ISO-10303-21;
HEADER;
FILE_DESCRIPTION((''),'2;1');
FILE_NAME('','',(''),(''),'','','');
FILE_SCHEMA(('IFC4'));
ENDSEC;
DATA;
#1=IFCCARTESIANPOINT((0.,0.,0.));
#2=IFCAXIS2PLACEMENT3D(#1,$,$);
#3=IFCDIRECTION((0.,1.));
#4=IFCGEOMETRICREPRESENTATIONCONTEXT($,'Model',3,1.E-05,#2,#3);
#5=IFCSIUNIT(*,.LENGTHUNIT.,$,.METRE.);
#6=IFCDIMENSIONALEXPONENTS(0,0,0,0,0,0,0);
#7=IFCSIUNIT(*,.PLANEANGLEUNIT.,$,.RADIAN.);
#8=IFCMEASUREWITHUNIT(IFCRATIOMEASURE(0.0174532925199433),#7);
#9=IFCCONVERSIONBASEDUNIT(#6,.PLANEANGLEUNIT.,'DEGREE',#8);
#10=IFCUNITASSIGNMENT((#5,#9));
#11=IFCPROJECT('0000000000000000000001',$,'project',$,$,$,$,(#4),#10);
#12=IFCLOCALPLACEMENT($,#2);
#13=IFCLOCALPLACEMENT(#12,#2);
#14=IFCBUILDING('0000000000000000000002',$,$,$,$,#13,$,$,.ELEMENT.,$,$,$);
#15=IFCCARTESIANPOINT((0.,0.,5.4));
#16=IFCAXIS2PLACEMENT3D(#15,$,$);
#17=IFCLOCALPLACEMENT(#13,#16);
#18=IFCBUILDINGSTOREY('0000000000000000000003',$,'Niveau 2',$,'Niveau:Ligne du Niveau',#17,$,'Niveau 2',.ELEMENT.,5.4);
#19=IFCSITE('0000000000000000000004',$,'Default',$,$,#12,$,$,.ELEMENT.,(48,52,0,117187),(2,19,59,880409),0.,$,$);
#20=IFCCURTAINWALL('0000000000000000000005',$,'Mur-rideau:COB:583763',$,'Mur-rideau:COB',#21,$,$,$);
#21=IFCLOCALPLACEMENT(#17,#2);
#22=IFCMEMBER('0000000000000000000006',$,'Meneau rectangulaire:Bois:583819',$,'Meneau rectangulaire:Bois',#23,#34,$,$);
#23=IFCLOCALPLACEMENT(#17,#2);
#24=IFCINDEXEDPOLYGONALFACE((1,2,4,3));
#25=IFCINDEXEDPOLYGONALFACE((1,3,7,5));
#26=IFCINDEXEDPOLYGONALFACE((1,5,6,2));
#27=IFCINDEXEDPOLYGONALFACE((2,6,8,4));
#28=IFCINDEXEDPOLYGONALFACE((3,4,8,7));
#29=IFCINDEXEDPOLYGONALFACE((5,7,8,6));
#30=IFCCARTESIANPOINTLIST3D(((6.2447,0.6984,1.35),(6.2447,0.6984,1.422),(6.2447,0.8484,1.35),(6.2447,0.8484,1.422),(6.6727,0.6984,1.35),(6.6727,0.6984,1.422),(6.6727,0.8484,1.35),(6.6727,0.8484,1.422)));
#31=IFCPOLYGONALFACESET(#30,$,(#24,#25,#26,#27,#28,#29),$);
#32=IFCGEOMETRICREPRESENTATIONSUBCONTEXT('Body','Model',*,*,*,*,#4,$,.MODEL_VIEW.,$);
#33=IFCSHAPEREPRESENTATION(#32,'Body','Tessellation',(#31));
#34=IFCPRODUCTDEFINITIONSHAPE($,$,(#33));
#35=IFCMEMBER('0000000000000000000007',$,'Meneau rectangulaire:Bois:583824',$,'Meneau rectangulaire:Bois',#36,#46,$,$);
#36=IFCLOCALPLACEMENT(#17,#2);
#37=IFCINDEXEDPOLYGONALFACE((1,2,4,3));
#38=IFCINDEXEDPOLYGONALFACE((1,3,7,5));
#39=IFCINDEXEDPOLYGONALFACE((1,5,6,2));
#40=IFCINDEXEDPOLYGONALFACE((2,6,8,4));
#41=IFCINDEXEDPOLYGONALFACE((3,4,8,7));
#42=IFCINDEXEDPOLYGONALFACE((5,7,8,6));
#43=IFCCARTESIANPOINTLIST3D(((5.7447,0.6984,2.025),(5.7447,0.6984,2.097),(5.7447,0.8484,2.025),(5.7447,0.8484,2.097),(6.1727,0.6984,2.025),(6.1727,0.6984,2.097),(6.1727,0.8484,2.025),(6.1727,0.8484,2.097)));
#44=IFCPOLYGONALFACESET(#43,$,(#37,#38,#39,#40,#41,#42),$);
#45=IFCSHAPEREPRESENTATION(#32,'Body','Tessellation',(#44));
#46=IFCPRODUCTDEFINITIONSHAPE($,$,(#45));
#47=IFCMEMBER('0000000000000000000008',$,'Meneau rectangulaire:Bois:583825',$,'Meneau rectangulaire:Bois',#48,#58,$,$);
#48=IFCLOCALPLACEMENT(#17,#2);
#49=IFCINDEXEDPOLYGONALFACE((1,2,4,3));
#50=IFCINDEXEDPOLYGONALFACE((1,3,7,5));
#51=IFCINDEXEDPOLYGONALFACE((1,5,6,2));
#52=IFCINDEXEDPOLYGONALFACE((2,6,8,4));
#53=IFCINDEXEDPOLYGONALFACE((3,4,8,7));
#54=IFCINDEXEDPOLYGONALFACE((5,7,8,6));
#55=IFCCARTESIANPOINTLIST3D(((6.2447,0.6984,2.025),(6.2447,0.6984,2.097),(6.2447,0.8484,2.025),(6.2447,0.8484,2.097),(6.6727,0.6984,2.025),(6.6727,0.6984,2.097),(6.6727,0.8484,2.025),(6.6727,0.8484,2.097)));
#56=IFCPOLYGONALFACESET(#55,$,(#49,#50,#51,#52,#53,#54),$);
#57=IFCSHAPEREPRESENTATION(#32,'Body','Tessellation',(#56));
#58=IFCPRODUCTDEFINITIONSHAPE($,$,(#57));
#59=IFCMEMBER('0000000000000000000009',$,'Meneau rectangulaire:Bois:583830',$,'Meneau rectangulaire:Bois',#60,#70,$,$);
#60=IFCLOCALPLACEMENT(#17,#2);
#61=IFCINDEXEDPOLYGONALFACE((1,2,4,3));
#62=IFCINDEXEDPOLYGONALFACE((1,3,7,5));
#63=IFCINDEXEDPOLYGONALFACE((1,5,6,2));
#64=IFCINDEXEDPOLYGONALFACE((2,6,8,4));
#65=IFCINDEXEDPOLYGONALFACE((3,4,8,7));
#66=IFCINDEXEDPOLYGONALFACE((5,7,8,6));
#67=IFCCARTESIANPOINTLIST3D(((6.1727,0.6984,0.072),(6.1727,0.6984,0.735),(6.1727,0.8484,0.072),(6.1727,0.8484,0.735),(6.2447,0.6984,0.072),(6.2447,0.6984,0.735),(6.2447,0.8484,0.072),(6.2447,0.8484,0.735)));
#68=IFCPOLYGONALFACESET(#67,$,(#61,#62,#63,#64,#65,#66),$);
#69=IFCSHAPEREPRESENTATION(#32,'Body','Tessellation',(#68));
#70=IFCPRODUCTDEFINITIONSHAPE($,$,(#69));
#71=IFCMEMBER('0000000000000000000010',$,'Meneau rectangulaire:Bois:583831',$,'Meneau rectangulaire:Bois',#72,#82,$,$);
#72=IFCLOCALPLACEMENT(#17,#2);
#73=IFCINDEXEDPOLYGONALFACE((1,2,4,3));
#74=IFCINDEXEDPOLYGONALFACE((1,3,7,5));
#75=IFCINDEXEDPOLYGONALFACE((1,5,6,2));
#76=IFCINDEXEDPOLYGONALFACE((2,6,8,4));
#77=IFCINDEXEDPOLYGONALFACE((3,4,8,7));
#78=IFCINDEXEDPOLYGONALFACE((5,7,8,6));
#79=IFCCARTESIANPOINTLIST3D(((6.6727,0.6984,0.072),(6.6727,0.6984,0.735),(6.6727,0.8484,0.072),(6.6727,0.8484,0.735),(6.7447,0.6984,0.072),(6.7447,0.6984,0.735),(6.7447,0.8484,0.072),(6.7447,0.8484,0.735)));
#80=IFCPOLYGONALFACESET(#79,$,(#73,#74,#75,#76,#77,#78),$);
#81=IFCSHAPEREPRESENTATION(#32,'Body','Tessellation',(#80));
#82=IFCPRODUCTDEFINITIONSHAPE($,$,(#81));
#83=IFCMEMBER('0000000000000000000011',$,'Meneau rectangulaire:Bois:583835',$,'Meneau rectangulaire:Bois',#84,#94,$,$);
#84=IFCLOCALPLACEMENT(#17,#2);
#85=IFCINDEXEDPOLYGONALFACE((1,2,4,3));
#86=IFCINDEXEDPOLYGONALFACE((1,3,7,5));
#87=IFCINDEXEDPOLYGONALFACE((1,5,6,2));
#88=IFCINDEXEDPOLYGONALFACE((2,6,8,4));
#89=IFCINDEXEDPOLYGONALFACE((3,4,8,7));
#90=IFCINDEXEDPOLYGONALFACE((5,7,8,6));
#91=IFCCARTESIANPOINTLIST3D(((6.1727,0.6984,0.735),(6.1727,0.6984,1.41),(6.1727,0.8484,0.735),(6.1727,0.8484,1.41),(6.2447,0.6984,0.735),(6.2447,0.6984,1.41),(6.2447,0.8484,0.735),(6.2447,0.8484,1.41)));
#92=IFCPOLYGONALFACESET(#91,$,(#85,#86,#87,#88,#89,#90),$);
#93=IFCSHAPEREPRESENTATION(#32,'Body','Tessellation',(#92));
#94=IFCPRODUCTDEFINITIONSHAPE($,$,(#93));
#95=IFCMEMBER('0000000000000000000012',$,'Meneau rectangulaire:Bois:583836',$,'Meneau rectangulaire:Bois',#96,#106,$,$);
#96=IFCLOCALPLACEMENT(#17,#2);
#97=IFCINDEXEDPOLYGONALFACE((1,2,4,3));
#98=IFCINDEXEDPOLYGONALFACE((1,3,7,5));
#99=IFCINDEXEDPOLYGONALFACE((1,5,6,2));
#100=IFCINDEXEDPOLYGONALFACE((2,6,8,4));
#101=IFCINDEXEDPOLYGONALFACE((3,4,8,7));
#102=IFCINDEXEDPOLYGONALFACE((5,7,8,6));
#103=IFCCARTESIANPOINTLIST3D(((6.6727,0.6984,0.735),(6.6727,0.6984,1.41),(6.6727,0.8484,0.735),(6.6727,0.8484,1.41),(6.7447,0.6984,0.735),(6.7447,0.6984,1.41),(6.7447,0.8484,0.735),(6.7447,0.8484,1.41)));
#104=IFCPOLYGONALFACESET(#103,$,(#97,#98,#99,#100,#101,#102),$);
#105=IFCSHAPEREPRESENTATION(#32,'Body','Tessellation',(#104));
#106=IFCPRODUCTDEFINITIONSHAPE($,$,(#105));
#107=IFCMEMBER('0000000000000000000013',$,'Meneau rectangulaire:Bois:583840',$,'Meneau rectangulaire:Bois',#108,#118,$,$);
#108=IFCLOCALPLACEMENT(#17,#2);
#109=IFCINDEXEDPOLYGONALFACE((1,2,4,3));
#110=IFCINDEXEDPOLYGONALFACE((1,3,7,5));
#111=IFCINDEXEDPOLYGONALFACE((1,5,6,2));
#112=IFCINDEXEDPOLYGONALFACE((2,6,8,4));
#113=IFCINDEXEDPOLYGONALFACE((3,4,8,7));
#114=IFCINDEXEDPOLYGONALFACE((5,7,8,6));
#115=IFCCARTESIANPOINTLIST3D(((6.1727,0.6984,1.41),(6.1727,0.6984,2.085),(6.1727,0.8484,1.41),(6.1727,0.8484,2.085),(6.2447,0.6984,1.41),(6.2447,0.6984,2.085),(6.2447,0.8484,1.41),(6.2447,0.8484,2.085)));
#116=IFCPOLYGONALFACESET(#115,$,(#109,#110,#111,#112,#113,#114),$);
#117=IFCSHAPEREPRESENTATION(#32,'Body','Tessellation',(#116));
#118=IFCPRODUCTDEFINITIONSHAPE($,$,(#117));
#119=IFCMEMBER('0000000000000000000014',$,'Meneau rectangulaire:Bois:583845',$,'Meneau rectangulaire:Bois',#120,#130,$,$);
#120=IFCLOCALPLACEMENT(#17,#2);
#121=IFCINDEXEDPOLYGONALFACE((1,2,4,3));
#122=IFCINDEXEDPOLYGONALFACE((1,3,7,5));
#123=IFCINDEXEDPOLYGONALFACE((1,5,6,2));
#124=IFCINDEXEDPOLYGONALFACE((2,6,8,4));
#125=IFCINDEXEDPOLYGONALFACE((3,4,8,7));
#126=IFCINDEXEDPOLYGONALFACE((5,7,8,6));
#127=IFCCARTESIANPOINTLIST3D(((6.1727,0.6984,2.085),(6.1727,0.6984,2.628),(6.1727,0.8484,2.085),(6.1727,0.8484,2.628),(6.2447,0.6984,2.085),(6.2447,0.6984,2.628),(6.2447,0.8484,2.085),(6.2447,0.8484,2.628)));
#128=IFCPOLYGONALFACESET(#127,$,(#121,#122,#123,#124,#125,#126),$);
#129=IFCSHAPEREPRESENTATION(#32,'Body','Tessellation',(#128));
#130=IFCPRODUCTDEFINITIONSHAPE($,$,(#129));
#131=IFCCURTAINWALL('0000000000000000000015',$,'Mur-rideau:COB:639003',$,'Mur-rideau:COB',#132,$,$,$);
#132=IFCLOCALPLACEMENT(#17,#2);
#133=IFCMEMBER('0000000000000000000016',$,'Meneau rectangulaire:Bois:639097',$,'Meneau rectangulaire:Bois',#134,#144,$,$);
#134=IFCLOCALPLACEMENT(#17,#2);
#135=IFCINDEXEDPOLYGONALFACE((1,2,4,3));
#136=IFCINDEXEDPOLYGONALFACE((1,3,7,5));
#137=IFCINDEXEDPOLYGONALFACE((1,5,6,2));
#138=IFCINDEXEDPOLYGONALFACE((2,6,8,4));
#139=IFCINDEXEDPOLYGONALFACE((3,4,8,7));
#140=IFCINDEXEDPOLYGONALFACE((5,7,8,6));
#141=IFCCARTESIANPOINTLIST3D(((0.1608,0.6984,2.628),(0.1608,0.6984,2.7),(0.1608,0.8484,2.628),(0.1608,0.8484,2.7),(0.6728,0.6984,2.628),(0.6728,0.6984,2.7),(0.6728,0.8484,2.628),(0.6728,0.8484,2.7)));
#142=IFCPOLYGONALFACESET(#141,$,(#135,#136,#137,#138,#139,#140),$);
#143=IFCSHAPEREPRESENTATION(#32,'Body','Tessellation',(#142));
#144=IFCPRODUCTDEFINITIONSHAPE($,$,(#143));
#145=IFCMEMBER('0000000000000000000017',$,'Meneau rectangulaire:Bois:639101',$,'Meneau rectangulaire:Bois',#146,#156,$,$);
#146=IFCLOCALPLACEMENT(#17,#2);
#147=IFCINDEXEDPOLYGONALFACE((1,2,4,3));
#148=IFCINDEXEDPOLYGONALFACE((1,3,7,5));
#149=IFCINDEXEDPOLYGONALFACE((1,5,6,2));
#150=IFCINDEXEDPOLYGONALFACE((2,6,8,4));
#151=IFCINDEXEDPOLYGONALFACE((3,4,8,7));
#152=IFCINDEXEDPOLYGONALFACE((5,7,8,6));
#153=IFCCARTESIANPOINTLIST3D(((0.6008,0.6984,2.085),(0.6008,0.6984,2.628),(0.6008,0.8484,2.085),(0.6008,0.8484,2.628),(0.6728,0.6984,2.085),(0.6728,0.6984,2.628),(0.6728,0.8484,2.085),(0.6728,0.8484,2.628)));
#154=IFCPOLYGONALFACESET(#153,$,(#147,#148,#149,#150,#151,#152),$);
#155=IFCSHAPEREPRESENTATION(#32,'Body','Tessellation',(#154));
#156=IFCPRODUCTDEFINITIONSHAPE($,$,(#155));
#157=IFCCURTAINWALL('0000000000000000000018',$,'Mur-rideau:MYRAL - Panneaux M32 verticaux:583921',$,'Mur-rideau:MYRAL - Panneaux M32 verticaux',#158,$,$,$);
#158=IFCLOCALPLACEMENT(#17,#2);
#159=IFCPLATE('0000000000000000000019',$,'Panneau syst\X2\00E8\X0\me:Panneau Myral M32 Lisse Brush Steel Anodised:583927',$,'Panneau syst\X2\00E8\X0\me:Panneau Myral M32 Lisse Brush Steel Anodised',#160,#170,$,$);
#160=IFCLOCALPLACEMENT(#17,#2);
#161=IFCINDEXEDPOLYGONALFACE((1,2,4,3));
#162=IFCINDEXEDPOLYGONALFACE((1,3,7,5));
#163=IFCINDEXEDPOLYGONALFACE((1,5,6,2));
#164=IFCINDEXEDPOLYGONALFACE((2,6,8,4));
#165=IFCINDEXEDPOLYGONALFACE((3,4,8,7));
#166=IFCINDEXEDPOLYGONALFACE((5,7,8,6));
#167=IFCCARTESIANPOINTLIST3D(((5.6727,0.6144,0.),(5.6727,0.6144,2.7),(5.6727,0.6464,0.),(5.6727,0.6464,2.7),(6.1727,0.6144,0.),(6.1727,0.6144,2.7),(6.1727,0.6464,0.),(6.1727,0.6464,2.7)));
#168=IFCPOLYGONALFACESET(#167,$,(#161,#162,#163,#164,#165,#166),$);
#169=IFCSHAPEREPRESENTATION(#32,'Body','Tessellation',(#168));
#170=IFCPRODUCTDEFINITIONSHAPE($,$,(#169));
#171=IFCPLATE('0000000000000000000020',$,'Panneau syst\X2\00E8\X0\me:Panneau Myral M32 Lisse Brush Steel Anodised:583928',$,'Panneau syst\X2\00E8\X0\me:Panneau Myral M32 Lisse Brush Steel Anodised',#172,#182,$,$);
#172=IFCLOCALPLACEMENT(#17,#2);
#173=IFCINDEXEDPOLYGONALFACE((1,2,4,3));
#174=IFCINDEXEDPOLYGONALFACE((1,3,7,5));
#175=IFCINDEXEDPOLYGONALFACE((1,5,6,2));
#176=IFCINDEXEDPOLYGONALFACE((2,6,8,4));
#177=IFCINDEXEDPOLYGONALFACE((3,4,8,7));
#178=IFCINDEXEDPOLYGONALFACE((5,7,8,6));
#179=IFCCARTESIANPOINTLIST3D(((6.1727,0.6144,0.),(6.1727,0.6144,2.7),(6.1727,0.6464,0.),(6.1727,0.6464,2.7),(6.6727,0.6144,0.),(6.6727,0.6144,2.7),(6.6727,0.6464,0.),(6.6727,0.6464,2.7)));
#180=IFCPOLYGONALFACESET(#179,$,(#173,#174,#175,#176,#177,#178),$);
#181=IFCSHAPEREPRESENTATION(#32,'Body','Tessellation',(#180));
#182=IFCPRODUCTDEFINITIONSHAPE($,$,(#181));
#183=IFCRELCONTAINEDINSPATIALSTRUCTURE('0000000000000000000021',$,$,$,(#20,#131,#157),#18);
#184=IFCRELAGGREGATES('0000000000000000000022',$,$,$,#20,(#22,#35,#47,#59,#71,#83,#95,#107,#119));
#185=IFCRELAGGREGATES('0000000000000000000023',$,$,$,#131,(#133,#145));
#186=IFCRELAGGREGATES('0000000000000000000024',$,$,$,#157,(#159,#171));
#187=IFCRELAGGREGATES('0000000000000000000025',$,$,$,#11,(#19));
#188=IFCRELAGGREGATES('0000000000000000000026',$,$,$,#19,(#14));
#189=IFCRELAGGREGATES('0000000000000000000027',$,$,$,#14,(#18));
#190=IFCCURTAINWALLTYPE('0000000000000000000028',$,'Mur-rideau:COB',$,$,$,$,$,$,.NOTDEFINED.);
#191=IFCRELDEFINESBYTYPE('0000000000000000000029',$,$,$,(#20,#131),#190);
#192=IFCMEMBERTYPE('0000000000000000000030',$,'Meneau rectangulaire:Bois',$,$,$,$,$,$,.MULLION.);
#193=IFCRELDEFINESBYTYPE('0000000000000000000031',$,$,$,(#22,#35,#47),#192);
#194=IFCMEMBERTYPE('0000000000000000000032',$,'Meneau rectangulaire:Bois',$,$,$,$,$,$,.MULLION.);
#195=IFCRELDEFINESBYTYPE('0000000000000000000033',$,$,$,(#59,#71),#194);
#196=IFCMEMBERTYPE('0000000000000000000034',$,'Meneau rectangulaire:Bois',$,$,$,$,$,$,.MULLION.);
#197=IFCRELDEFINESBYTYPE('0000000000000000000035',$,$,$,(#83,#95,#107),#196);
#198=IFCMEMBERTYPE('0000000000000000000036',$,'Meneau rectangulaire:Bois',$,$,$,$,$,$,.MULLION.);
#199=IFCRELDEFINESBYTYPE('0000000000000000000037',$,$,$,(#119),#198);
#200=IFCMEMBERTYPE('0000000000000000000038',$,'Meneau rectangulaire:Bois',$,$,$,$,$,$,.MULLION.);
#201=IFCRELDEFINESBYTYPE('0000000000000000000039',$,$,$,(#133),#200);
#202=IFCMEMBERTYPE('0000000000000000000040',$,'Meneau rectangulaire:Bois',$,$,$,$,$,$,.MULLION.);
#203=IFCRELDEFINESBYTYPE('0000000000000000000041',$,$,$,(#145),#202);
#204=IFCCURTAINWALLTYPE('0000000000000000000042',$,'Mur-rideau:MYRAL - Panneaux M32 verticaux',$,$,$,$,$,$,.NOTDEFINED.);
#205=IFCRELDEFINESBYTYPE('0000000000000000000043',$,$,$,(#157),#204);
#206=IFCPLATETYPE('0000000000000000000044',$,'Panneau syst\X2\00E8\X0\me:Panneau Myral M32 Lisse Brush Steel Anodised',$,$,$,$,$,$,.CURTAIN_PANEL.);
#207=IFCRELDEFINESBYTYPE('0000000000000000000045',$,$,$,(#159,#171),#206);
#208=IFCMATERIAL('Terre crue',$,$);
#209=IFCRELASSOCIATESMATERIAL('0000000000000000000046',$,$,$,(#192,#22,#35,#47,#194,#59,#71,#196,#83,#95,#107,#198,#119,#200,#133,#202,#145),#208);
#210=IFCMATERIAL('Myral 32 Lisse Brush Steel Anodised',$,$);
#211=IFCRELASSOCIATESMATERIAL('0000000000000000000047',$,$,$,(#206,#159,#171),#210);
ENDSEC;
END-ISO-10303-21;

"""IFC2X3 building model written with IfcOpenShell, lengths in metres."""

from ifc_helpers import new_model, entity, si_unit, converted_unit, direction, frame, origin, origin_2d_with_axis, place, context, subcontext, project, spatial, rectangle, extrude, source, transform, mapped, material, type_object, type_shapes, element, aggregate, save


model = new_model("IFC2X3")

# Units and contexts
model_context = context("Model", 3, precision=1e-05, world=origin(), true_north=direction((0.0, 1.0)))
body_context = subcontext(model_context, "Body", "Model", "MODEL_VIEW")
ifc_project = project(units=[si_unit("LENGTHUNIT", "METRE"), converted_unit("PLANEANGLEUNIT", "DEGREE", entity("IfcRatioMeasure", 0.0174532925199433), si_unit("PLANEANGLEUNIT", "RADIAN"), dimensions=[0, 0, 0, 0, 0, 0, 0])], contexts=[model_context])

# Site, building, storey
site_placement = place(None, origin())
site = spatial("IfcSite", under=ifc_project, at=site_placement, Name="Default", CompositionType="ELEMENT", RefLatitude=(48, 52, 0, 117187), RefLongitude=(2, 19, 59, 880409), RefElevation=0.0)
building_placement = place(site_placement, origin())
building = spatial("IfcBuilding", under=site, at=building_placement, CompositionType="ELEMENT")
storey_placement = place(building_placement, frame((0.0, 0.0, 5.4)))
storey = spatial("IfcBuildingStorey", under=building, at=storey_placement, Name="Niveau 2", ObjectType="Niveau:Ligne du Niveau", LongName="Niveau 2", CompositionType="ELEMENT", Elevation=5.4)

# Curtain walls, members
curtain_wall_type_1 = type_object("IfcCurtainWallType", Name="Mur-rideau:COB", PredefinedType="NOTDEFINED")
curtain_wall_1_placement = place(storey_placement, frame((0.0, 0.0, -5.4)))
curtain_wall_1 = element("IfcCurtainWall", 1, at=curtain_wall_1_placement, inside=storey, type_object=curtain_wall_type_1, Name="Mur-rideau:COB:583763", ObjectType="Mur-rideau:COB")
ifc_material_1 = material(Name="Terre crue")
member_type_1 = type_object("IfcMemberType", Name="Meneau rectangulaire:Bois", PredefinedType="MULLION", material=ifc_material_1)
shared_shape_1 = source(origin(), body_context, "Body", "SweptSolid", [
    extrude(rectangle(XDim=0.15, YDim=0.072, at=origin_2d_with_axis()), frame((-0.024, 0.0, -0.428), z_axis=(0.0, 0.0, 1.0), x_axis=(0.0, -1.0, 0.0)), (0.0, 0.0, 1.0), 0.428),
])
type_shapes(member_type_1, [shared_shape_1])
member_1_placement = place(storey_placement, frame((6.6727, 0.7734, 1.41), z_axis=(1.0, 0.0, 0.0), x_axis=(0.0, 0.0, 1.0)))
member_1 = element("IfcMember", 2, at=member_1_placement, type_object=member_type_1, material=ifc_material_1, Name="Meneau rectangulaire:Bois:583819", ObjectType="Meneau rectangulaire:Bois", context=body_context, shape_type="MappedRepresentation", body=[
    mapped(shared_shape_1, transform((0.0, 0.0, 0.0), scale=1.0)),
])
member_2_placement = place(storey_placement, frame((6.1727, 0.7734, 2.085), z_axis=(1.0, 0.0, 0.0), x_axis=(0.0, 0.0, 1.0)))
member_2 = element("IfcMember", 3, at=member_2_placement, type_object=member_type_1, material=ifc_material_1, Name="Meneau rectangulaire:Bois:583824", ObjectType="Meneau rectangulaire:Bois", context=body_context, shape_type="MappedRepresentation", body=[
    mapped(shared_shape_1, transform((0.0, 0.0, 0.0), scale=1.0)),
])
member_3_placement = place(storey_placement, frame((6.6727, 0.7734, 2.085), z_axis=(1.0, 0.0, 0.0), x_axis=(0.0, 0.0, 1.0)))
member_3 = element("IfcMember", 4, at=member_3_placement, type_object=member_type_1, material=ifc_material_1, Name="Meneau rectangulaire:Bois:583825", ObjectType="Meneau rectangulaire:Bois", context=body_context, shape_type="MappedRepresentation", body=[
    mapped(shared_shape_1, transform((0.0, 0.0, 0.0), scale=1.0)),
])
member_type_2 = type_object("IfcMemberType", Name="Meneau rectangulaire:Bois", PredefinedType="MULLION", material=ifc_material_1)
shared_shape_2 = source(origin(), body_context, "Body", "SweptSolid", [
    extrude(rectangle(XDim=0.15, YDim=0.072, at=origin_2d_with_axis()), frame((-0.024, 0.0, -0.663), z_axis=(0.0, 0.0, 1.0), x_axis=(0.0, -1.0, 0.0)), (0.0, 0.0, 1.0), 0.663),
])
type_shapes(member_type_2, [shared_shape_2])
member_4_placement = place(storey_placement, frame((6.2327, 0.7734, 0.072), z_axis=(0.0, 0.0, -1.0), x_axis=(1.0, 0.0, 0.0)))
member_4 = element("IfcMember", 5, at=member_4_placement, type_object=member_type_2, material=ifc_material_1, Name="Meneau rectangulaire:Bois:583830", ObjectType="Meneau rectangulaire:Bois", context=body_context, shape_type="MappedRepresentation", body=[
    mapped(shared_shape_2, transform((0.0, 0.0, 0.0), scale=1.0)),
])
member_5_placement = place(storey_placement, frame((6.7327, 0.7734, 0.072), z_axis=(0.0, 0.0, -1.0), x_axis=(1.0, 0.0, 0.0)))
member_5 = element("IfcMember", 6, at=member_5_placement, type_object=member_type_2, material=ifc_material_1, Name="Meneau rectangulaire:Bois:583831", ObjectType="Meneau rectangulaire:Bois", context=body_context, shape_type="MappedRepresentation", body=[
    mapped(shared_shape_2, transform((0.0, 0.0, 0.0), scale=1.0)),
])
member_type_3 = type_object("IfcMemberType", Name="Meneau rectangulaire:Bois", PredefinedType="MULLION", material=ifc_material_1)
shared_shape_3 = source(origin(), body_context, "Body", "SweptSolid", [
    extrude(rectangle(XDim=0.15, YDim=0.072, at=origin_2d_with_axis()), frame((-0.024, 0.0, -0.675), z_axis=(0.0, 0.0, 1.0), x_axis=(0.0, -1.0, 0.0)), (0.0, 0.0, 1.0), 0.675),
])
type_shapes(member_type_3, [shared_shape_3])
member_6_placement = place(storey_placement, frame((6.2327, 0.7734, 0.735), z_axis=(0.0, 0.0, -1.0), x_axis=(1.0, 0.0, 0.0)))
member_6 = element("IfcMember", 7, at=member_6_placement, type_object=member_type_3, material=ifc_material_1, Name="Meneau rectangulaire:Bois:583835", ObjectType="Meneau rectangulaire:Bois", context=body_context, shape_type="MappedRepresentation", body=[
    mapped(shared_shape_3, transform((0.0, 0.0, 0.0), scale=1.0)),
])
member_7_placement = place(storey_placement, frame((6.7327, 0.7734, 0.735), z_axis=(0.0, 0.0, -1.0), x_axis=(1.0, 0.0, 0.0)))
member_7 = element("IfcMember", 8, at=member_7_placement, type_object=member_type_3, material=ifc_material_1, Name="Meneau rectangulaire:Bois:583836", ObjectType="Meneau rectangulaire:Bois", context=body_context, shape_type="MappedRepresentation", body=[
    mapped(shared_shape_3, transform((0.0, 0.0, 0.0), scale=1.0)),
])
member_8_placement = place(storey_placement, frame((6.2327, 0.7734, 1.41), z_axis=(0.0, 0.0, -1.0), x_axis=(1.0, 0.0, 0.0)))
member_8 = element("IfcMember", 9, at=member_8_placement, type_object=member_type_3, material=ifc_material_1, Name="Meneau rectangulaire:Bois:583840", ObjectType="Meneau rectangulaire:Bois", context=body_context, shape_type="MappedRepresentation", body=[
    mapped(shared_shape_3, transform((0.0, 0.0, 0.0), scale=1.0)),
])
member_type_4 = type_object("IfcMemberType", Name="Meneau rectangulaire:Bois", PredefinedType="MULLION", material=ifc_material_1)
shared_shape_4 = source(origin(), body_context, "Body", "SweptSolid", [
    extrude(rectangle(XDim=0.15, YDim=0.072, at=origin_2d_with_axis()), frame((-0.024, 0.0, -0.543), z_axis=(0.0, 0.0, 1.0), x_axis=(0.0, -1.0, 0.0)), (0.0, 0.0, 1.0), 0.543),
])
type_shapes(member_type_4, [shared_shape_4])
member_9_placement = place(storey_placement, frame((6.2327, 0.7734, 2.085), z_axis=(0.0, 0.0, -1.0), x_axis=(1.0, 0.0, 0.0)))
member_9 = element("IfcMember", 10, at=member_9_placement, type_object=member_type_4, material=ifc_material_1, Name="Meneau rectangulaire:Bois:583845", ObjectType="Meneau rectangulaire:Bois", context=body_context, shape_type="MappedRepresentation", body=[
    mapped(shared_shape_4, transform((0.0, 0.0, 0.0), scale=1.0)),
])
aggregate(curtain_wall_1, [member_1, member_2, member_3, member_4, member_5, member_6, member_7, member_8, member_9])
curtain_wall_2_placement = place(storey_placement, frame((0.0, 0.0, -5.4)))
curtain_wall_2 = element("IfcCurtainWall", 11, at=curtain_wall_2_placement, inside=storey, type_object=curtain_wall_type_1, Name="Mur-rideau:COB:639003", ObjectType="Mur-rideau:COB")
member_type_5 = type_object("IfcMemberType", Name="Meneau rectangulaire:Bois", PredefinedType="MULLION", material=ifc_material_1)
shared_shape_5 = source(origin(), body_context, "Body", "SweptSolid", [
    extrude(rectangle(XDim=0.15, YDim=0.072, at=origin_2d_with_axis()), frame((-0.036, 0.0, -0.512), z_axis=(0.0, 0.0, 1.0), x_axis=(0.0, -1.0, 0.0)), (0.0, 0.0, 1.0), 0.512),
])
type_shapes(member_type_5, [shared_shape_5])
member_10_placement = place(storey_placement, frame((0.6728, 0.7734, 2.7), z_axis=(1.0, 0.0, 0.0), x_axis=(0.0, 0.0, 1.0)))
member_10 = element("IfcMember", 12, at=member_10_placement, type_object=member_type_5, material=ifc_material_1, Name="Meneau rectangulaire:Bois:639097", ObjectType="Meneau rectangulaire:Bois", context=body_context, shape_type="MappedRepresentation", body=[
    mapped(shared_shape_5, transform((0.0, 0.0, 0.0), scale=1.0)),
])
member_type_6 = type_object("IfcMemberType", Name="Meneau rectangulaire:Bois", PredefinedType="MULLION", material=ifc_material_1)
shared_shape_6 = source(origin(), body_context, "Body", "SweptSolid", [
    extrude(rectangle(XDim=0.15, YDim=0.072, at=origin_2d_with_axis()), frame((-0.024, 0.0, -0.543), z_axis=(0.0, 0.0, 1.0), x_axis=(0.0, -1.0, 0.0)), (0.0, 0.0, 1.0), 0.543),
])
type_shapes(member_type_6, [shared_shape_6])
member_11_placement = place(storey_placement, frame((0.6608, 0.7734, 2.085), z_axis=(0.0, 0.0, -1.0), x_axis=(1.0, 0.0, 0.0)))
member_11 = element("IfcMember", 13, at=member_11_placement, type_object=member_type_6, material=ifc_material_1, Name="Meneau rectangulaire:Bois:639101", ObjectType="Meneau rectangulaire:Bois", context=body_context, shape_type="MappedRepresentation", body=[
    mapped(shared_shape_6, transform((0.0, 0.0, 0.0), scale=1.0)),
])
aggregate(curtain_wall_2, [member_10, member_11])

# Curtain wall, plates
curtain_wall_type_2 = type_object("IfcCurtainWallType", Name="Mur-rideau:MYRAL - Panneaux M32 verticaux", PredefinedType="NOTDEFINED")
curtain_wall_3_placement = place(storey_placement, frame((0.0, 0.0, -5.4)))
curtain_wall_3 = element("IfcCurtainWall", 14, at=curtain_wall_3_placement, inside=storey, type_object=curtain_wall_type_2, Name="Mur-rideau:MYRAL - Panneaux M32 verticaux:583921", ObjectType="Mur-rideau:MYRAL - Panneaux M32 verticaux")
ifc_material_2 = material(Name="Myral 32 Lisse Brush Steel Anodised")
plate_type = type_object("IfcPlateType", Name="Panneau système:Panneau Myral M32 Lisse Brush Steel Anodised", PredefinedType="CURTAIN_PANEL", material=ifc_material_2)
shared_shape_7 = source(origin(), body_context, "Body", "SweptSolid", [
    extrude(rectangle(XDim=0.032, YDim=0.5, at=origin_2d_with_axis()), frame((0.0, -0.016, 0.0), z_axis=(0.0, 0.0, 1.0), x_axis=(0.0, 1.0, 0.0)), (0.0, 0.0, 1.0), 2.7),
])
type_shapes(plate_type, [shared_shape_7])
plate_1_placement = place(curtain_wall_3_placement, frame((5.9227, 0.6464, 5.4)))
plate_1 = element("IfcPlate", 15, at=plate_1_placement, type_object=plate_type, material=ifc_material_2, Name="Panneau système:Panneau Myral M32 Lisse Brush Steel Anodised:583927", ObjectType="Panneau système:Panneau Myral M32 Lisse Brush Steel Anodised", context=body_context, shape_type="MappedRepresentation", body=[
    mapped(shared_shape_7, transform((0.0, 0.0, 0.0), scale=1.0)),
])
plate_2_placement = place(curtain_wall_3_placement, frame((6.4227, 0.6464, 5.4)))
plate_2 = element("IfcPlate", 16, at=plate_2_placement, type_object=plate_type, material=ifc_material_2, Name="Panneau système:Panneau Myral M32 Lisse Brush Steel Anodised:583928", ObjectType="Panneau système:Panneau Myral M32 Lisse Brush Steel Anodised", context=body_context, shape_type="MappedRepresentation", body=[
    mapped(shared_shape_7, transform((0.0, 0.0, 0.0), scale=1.0)),
])
aggregate(curtain_wall_3, [plate_1, plate_2])

save(model, "model.ifc")
